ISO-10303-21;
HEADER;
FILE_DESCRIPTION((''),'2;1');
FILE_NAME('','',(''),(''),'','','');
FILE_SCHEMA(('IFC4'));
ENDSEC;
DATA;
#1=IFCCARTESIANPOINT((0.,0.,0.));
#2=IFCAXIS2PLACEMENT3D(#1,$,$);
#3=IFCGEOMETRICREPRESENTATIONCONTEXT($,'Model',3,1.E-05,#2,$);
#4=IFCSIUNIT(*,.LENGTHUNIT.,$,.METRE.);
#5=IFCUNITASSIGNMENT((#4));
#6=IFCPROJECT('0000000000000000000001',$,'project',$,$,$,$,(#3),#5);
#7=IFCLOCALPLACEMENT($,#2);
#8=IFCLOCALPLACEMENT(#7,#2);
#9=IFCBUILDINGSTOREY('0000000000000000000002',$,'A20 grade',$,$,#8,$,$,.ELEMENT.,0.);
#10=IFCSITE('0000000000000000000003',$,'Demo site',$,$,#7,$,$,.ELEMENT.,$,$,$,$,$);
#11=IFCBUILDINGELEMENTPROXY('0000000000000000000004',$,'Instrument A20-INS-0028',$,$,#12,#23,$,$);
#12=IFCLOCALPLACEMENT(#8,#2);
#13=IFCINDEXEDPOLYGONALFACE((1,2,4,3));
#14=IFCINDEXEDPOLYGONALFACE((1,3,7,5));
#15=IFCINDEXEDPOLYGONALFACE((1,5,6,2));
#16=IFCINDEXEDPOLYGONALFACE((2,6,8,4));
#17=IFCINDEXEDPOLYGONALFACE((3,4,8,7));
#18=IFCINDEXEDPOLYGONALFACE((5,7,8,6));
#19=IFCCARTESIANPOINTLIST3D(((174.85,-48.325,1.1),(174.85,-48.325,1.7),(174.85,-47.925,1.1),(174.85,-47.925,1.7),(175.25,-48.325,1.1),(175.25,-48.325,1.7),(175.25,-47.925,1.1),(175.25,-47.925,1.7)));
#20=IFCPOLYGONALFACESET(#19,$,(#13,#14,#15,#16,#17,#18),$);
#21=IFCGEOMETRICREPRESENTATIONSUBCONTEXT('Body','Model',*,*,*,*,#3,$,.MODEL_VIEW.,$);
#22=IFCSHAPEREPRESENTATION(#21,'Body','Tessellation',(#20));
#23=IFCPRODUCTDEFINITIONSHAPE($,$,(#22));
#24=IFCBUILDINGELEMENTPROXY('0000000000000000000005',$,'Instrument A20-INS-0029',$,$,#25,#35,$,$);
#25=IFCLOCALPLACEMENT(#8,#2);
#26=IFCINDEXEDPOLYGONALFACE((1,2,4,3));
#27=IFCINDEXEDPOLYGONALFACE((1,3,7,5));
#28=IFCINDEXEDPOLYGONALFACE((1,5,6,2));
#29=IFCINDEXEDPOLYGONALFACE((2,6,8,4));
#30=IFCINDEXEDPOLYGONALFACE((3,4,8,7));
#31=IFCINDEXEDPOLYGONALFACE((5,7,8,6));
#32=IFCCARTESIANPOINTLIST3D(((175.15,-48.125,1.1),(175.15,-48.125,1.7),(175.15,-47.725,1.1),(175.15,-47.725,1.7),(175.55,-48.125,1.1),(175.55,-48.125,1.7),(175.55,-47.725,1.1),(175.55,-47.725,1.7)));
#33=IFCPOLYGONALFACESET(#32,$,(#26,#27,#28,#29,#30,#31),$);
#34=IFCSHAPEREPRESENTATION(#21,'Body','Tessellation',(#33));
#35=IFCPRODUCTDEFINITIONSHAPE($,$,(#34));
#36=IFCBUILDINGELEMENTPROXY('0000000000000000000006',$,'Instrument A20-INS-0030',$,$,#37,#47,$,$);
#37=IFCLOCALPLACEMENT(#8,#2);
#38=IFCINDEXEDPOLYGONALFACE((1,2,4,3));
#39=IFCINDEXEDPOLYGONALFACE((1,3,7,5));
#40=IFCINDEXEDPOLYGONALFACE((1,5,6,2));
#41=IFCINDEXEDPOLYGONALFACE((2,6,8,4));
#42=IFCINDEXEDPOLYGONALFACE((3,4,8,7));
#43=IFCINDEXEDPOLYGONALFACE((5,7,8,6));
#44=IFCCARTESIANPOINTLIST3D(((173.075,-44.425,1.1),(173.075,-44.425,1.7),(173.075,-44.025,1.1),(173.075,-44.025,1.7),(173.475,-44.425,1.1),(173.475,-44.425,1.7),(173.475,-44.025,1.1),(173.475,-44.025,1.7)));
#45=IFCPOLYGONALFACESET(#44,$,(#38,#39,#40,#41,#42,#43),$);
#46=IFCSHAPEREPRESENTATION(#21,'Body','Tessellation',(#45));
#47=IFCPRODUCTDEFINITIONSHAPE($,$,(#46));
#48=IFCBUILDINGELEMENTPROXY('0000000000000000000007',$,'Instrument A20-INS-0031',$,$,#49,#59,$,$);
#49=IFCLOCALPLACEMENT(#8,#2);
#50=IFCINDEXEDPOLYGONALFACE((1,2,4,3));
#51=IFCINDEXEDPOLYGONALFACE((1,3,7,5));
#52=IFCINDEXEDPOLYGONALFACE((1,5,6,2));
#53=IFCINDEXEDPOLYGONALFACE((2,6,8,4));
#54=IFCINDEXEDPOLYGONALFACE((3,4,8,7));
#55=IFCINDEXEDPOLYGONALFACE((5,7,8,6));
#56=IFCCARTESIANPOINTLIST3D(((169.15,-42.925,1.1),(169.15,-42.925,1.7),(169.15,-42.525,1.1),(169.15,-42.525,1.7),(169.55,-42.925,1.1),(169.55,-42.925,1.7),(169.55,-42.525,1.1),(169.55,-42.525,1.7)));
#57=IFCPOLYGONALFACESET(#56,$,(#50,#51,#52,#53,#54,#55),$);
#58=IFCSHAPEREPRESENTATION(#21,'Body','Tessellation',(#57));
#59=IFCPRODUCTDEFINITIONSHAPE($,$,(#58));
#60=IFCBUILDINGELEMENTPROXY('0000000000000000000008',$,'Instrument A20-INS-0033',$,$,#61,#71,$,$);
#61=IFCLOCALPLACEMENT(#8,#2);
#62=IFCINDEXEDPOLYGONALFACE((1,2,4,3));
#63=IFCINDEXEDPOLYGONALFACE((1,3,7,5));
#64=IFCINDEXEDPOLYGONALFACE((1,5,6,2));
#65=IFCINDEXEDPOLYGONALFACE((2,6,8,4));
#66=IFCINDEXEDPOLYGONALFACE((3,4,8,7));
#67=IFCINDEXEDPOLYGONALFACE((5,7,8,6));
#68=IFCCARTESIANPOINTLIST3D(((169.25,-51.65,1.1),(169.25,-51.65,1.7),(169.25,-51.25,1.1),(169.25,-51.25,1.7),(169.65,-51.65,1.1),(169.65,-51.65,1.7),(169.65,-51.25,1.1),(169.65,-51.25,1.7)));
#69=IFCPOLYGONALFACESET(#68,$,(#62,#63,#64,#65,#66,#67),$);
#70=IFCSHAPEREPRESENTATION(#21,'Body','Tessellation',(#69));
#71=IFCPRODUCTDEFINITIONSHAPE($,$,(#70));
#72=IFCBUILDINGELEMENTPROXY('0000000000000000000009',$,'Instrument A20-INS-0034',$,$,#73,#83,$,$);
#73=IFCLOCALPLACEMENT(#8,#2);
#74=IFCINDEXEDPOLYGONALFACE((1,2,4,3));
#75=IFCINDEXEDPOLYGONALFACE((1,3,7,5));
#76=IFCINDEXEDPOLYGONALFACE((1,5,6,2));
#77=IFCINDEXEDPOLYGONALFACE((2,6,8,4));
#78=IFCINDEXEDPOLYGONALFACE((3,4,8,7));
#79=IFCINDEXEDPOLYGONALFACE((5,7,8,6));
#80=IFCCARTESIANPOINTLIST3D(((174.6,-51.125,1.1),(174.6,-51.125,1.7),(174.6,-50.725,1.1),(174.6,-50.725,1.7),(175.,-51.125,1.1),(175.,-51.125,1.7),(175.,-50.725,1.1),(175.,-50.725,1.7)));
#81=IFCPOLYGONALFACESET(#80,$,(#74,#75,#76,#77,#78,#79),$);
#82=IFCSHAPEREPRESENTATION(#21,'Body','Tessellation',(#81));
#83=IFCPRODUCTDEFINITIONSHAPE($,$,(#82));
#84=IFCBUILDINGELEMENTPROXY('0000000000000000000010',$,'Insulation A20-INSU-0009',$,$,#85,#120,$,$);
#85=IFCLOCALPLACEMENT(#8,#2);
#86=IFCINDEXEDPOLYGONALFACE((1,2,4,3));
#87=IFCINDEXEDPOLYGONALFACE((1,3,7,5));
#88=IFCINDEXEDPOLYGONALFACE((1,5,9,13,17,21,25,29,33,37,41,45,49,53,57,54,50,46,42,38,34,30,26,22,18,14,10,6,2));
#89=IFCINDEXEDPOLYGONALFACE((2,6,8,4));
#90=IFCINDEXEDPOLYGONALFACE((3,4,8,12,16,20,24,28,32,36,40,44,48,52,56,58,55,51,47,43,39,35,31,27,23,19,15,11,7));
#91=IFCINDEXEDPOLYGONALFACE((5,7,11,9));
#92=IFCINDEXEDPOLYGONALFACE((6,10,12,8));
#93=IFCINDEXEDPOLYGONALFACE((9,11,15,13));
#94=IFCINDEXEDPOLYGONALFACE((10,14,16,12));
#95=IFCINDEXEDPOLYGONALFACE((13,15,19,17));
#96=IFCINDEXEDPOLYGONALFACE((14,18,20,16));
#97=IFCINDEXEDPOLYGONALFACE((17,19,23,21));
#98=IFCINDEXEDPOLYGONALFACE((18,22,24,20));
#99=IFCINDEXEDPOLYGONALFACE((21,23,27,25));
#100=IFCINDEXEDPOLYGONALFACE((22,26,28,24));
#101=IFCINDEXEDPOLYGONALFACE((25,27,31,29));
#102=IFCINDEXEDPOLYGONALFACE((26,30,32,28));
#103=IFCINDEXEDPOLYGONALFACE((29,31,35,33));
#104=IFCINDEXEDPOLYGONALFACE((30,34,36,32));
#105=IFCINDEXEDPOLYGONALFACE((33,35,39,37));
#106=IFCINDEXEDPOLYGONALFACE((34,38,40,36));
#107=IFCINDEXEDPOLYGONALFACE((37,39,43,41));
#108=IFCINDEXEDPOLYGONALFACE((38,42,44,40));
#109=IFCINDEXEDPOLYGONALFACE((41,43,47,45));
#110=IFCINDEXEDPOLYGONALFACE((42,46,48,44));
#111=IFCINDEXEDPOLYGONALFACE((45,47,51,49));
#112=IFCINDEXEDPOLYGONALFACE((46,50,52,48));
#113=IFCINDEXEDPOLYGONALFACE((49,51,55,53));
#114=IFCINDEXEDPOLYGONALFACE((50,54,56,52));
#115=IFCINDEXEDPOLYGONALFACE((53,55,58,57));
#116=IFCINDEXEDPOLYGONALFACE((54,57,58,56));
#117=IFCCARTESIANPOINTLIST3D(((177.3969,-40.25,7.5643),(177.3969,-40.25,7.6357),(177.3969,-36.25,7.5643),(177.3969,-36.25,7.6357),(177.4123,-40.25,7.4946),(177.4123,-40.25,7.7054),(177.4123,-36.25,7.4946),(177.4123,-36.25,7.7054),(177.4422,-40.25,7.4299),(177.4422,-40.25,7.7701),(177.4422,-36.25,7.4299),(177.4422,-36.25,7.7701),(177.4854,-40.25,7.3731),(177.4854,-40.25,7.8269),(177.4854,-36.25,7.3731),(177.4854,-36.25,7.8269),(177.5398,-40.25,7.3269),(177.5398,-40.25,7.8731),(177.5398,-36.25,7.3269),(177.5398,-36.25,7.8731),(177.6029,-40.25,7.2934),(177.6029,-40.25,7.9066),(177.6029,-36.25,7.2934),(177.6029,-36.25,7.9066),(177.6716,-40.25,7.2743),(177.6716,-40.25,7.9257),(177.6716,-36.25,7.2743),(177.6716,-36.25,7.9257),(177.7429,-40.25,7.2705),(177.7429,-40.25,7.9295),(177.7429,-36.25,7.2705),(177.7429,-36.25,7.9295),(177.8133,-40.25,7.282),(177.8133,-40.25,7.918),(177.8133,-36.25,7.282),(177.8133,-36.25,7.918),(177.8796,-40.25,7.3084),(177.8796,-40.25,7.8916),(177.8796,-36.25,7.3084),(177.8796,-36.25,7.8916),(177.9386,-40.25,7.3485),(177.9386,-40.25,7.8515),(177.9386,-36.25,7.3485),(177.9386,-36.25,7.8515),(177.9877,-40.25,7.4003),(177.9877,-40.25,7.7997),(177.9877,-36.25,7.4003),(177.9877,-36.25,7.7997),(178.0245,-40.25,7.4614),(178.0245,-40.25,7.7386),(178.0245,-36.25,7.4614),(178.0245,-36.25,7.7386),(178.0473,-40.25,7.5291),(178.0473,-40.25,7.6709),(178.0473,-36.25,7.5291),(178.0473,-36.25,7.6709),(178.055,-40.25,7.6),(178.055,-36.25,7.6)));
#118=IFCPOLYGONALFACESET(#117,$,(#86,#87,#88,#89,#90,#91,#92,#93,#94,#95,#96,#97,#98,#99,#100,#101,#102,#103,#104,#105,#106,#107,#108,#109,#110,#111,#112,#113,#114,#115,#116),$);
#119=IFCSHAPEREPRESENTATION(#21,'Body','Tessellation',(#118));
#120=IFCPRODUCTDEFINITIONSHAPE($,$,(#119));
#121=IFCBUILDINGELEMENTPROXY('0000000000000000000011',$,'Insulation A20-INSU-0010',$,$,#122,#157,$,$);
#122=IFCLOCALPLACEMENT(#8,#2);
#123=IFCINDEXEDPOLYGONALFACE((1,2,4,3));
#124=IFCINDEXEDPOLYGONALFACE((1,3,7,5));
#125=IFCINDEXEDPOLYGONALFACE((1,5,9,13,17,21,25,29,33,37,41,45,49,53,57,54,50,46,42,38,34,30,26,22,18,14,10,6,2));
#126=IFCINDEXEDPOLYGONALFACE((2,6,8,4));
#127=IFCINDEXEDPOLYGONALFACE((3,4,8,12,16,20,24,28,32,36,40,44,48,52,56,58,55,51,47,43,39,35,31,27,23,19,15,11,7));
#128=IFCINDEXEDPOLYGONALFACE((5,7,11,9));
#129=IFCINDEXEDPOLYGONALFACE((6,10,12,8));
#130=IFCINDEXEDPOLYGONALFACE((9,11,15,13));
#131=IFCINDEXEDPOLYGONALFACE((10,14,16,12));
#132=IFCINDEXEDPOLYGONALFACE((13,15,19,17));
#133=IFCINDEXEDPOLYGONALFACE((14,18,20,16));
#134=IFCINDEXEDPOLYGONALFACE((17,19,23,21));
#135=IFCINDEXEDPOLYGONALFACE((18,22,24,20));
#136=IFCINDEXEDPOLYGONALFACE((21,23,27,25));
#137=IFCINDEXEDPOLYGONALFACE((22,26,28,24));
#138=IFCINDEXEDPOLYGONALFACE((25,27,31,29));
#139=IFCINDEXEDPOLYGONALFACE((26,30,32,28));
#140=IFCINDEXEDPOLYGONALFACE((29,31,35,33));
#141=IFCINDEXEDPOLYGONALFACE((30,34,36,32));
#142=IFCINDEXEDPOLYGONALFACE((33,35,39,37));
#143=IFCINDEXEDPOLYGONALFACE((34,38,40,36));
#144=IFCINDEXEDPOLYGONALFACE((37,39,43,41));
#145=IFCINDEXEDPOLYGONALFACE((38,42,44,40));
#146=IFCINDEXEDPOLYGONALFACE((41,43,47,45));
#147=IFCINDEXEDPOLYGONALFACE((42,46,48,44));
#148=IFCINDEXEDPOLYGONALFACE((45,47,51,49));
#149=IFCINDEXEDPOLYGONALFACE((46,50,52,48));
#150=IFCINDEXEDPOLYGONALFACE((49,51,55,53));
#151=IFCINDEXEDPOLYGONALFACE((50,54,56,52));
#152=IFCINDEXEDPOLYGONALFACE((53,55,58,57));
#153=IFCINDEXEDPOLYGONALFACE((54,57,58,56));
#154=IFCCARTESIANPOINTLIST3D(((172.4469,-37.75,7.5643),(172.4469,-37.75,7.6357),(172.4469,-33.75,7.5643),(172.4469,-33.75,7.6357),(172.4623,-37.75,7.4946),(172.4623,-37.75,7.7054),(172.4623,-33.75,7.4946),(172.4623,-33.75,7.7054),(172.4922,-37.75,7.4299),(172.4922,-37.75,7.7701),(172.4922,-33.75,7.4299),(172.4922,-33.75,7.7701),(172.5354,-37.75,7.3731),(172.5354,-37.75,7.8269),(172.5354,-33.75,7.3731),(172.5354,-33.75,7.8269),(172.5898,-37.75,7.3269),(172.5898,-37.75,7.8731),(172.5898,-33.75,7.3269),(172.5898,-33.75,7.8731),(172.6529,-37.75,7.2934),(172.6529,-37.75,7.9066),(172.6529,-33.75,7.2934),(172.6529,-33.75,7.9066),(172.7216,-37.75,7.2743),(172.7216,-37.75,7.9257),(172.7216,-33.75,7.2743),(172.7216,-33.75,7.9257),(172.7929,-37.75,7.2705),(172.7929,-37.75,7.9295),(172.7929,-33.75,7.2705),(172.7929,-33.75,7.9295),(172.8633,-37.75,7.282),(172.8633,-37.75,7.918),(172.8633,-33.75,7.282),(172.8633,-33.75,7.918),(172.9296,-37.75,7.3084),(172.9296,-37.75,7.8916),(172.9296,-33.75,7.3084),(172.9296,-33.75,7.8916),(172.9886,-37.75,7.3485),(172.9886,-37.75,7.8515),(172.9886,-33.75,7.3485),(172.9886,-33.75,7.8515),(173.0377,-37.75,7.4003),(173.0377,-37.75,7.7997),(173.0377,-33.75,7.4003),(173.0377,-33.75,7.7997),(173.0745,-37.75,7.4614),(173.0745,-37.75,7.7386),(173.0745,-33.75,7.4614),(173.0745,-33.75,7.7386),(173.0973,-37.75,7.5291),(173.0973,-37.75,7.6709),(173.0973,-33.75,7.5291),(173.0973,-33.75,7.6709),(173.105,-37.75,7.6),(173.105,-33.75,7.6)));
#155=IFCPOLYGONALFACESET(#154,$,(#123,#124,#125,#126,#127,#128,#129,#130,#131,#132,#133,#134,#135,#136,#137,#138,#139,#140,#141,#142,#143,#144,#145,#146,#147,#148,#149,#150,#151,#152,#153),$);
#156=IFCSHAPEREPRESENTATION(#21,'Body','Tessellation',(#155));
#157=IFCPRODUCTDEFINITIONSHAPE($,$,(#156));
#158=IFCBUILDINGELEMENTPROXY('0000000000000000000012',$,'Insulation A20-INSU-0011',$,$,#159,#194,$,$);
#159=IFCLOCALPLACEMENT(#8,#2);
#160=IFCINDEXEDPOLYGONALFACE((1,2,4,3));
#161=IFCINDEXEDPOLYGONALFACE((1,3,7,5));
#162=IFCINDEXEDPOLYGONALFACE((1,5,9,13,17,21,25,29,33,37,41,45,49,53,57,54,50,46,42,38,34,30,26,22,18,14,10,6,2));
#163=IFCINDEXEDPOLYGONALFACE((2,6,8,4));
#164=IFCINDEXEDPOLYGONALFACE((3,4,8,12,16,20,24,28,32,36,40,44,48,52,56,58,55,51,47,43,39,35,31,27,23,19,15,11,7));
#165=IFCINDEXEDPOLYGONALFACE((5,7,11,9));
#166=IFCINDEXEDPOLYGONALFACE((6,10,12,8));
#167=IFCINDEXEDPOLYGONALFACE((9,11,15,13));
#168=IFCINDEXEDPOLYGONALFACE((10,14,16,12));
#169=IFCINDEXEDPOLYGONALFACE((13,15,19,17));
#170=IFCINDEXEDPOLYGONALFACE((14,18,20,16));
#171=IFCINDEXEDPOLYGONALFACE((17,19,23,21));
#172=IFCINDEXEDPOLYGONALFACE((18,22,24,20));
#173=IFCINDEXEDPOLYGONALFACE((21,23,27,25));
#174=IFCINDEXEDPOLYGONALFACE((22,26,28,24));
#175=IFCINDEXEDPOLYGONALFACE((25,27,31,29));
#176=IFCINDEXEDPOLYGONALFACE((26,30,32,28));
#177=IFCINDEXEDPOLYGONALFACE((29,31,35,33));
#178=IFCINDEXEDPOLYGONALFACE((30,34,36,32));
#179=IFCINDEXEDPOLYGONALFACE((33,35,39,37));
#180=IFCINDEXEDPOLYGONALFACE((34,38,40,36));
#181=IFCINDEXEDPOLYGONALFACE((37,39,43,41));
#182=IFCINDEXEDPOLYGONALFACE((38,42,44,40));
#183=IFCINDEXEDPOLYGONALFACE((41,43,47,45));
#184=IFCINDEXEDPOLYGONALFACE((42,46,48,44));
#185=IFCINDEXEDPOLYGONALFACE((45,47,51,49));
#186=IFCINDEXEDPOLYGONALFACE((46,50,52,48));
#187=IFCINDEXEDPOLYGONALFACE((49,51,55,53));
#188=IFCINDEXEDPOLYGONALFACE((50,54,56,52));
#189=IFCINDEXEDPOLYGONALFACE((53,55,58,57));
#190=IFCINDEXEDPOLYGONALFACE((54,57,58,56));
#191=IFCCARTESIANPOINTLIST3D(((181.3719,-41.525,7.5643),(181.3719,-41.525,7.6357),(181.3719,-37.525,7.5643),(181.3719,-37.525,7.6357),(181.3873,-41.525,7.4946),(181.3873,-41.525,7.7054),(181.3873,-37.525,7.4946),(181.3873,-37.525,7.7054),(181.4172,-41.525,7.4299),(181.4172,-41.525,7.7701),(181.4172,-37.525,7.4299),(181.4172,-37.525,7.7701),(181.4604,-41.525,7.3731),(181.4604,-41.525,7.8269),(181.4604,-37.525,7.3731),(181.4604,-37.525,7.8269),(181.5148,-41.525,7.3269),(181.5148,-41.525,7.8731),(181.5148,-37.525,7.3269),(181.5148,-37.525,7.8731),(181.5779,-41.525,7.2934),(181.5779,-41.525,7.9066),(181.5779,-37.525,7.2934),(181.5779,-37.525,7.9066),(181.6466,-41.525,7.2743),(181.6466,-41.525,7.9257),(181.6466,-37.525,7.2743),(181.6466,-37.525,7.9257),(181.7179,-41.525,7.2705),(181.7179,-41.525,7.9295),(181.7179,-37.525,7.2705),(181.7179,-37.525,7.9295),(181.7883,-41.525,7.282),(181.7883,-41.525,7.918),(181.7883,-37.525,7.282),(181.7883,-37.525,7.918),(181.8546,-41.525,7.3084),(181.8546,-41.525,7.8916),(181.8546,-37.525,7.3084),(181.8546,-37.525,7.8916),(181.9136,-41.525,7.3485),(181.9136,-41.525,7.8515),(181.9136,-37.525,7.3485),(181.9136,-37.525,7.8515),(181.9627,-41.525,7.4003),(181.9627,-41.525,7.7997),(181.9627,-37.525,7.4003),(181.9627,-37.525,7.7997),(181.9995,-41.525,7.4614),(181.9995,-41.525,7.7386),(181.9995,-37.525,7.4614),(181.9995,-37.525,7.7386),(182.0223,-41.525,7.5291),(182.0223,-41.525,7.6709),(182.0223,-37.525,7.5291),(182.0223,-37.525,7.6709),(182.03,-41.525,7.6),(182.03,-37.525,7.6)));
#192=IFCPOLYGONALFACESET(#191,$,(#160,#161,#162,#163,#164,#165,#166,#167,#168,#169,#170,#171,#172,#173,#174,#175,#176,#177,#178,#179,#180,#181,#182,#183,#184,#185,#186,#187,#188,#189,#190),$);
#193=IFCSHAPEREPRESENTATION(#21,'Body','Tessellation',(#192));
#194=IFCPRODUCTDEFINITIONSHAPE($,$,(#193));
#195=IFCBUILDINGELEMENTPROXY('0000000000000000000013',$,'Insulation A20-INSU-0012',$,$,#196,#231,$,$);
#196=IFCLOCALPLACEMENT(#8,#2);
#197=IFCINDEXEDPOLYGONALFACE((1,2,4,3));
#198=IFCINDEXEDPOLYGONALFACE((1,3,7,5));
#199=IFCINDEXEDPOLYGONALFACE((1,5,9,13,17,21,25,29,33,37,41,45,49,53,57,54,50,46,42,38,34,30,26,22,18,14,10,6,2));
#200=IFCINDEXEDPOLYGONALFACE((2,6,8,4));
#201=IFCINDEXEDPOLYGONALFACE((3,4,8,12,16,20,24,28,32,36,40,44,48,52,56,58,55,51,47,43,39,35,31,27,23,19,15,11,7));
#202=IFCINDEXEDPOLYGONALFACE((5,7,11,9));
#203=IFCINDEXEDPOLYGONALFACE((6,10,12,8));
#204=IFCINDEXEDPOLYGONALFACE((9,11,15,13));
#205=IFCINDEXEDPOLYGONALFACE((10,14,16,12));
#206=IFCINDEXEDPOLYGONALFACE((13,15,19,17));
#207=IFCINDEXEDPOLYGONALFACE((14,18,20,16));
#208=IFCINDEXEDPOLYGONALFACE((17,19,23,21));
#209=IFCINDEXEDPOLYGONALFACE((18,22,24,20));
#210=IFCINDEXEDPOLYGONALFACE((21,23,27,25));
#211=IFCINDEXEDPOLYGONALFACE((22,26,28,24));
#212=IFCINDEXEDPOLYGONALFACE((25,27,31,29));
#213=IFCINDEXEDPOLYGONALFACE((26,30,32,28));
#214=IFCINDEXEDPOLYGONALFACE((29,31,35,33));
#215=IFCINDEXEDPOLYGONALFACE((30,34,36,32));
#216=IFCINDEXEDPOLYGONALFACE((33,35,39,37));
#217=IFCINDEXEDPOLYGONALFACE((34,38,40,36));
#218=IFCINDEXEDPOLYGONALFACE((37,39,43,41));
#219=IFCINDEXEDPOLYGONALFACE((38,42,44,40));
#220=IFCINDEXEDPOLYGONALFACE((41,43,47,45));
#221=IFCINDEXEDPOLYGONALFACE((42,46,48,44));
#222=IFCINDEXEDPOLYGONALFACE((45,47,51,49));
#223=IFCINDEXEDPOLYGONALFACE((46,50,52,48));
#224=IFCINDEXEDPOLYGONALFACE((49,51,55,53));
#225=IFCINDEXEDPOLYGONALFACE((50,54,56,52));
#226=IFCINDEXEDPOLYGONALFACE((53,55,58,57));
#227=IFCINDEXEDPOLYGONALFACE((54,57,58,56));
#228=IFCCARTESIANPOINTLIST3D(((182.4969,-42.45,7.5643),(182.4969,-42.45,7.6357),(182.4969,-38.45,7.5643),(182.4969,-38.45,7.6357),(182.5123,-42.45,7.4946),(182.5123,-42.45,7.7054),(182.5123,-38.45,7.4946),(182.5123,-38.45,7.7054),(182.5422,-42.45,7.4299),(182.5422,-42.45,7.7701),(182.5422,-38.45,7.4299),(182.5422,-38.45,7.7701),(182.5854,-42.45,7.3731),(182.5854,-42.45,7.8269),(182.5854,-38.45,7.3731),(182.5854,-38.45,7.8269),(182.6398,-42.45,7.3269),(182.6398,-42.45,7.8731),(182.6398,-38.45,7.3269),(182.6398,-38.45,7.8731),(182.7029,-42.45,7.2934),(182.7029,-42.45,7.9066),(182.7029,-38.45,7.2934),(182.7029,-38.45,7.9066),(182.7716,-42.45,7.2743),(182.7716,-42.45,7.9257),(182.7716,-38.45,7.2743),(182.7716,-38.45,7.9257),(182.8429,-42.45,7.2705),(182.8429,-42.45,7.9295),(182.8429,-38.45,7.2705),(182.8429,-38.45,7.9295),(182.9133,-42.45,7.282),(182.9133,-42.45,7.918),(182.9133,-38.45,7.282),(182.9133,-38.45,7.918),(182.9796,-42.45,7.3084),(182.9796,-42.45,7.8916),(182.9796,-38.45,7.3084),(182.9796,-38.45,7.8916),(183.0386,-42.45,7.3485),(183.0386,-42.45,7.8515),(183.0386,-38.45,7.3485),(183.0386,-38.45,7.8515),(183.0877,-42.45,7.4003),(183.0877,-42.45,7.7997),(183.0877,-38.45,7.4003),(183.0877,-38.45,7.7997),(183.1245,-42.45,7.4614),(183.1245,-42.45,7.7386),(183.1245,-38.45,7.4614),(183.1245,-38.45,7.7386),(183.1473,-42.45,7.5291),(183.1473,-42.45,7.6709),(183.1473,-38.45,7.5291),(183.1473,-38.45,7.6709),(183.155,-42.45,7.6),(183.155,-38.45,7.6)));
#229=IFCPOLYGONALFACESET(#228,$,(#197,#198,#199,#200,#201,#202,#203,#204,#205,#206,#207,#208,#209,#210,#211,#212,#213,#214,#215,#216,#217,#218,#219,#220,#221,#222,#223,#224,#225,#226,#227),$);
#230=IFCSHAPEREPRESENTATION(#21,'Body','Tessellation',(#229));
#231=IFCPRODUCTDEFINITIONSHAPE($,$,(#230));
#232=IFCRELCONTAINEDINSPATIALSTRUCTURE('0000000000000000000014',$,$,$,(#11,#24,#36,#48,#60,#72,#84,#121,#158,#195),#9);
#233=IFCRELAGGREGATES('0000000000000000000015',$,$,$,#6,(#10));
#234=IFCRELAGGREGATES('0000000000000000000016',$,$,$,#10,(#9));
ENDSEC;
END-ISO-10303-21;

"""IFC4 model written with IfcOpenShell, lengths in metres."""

from ifc_helpers import new_model, si_unit, frame, origin, place, context, subcontext, project, spatial, rectangle, circle, extrude, element, save


model = new_model("IFC4")

# Units and contexts
model_context = context("Model", 3, precision=1e-05, world=origin())
body_context = subcontext(model_context, "Body", "Model", "MODEL_VIEW")
ifc_project = project(units=[si_unit("LENGTHUNIT", "METRE")], contexts=[model_context])

# Site, storey
site_placement = place(None, origin())
site = spatial("IfcSite", under=ifc_project, at=site_placement, Name="Demo site", CompositionType="ELEMENT")
storey_placement = place(site_placement, origin())
storey = spatial("IfcBuildingStorey", under=site, at=storey_placement, Name="A20 grade", CompositionType="ELEMENT", Elevation=0.0)

# Building element proxies
for number, where, name in (
    (1, (175.05, -48.125, 1.1), "Instrument A20-INS-0028"),
    (2, (175.35, -47.925, 1.1), "Instrument A20-INS-0029"),
    (3, (173.275, -44.225, 1.1), "Instrument A20-INS-0030"),
    (4, (169.35, -42.725, 1.1), "Instrument A20-INS-0031"),
    (5, (169.45, -51.45, 1.1), "Instrument A20-INS-0033"),
    (6, (174.8, -50.925, 1.1), "Instrument A20-INS-0034"),
):
    element("IfcBuildingElementProxy", number, at=place(storey_placement, frame(where)), inside=storey, Name=name, context=body_context, shape_type="SweptSolid", body=[
        extrude(rectangle(XDim=0.4, YDim=0.4), origin(), (0.0, 0.0, 1.0), 0.6),
    ])
for number, where, name in (
    (7, (177.725, -40.25, 7.6), "Insulation A20-INSU-0009"),
    (8, (172.775, -37.75, 7.6), "Insulation A20-INSU-0010"),
    (9, (181.7, -41.525, 7.6), "Insulation A20-INSU-0011"),
    (10, (182.825, -42.45, 7.6), "Insulation A20-INSU-0012"),
):
    element("IfcBuildingElementProxy", number, at=place(storey_placement, frame(where)), inside=storey, Name=name, context=body_context, shape_type="SweptSolid", body=[
        extrude(circle(Radius=0.33), frame((0.0, 0.0, 0.0), z_axis=(0.0, 1.0, 0.0), x_axis=(1.0, 0.0, 0.0)), (0.0, 0.0, 1.0), 4.0),
    ])

save(model, "model.ifc")
